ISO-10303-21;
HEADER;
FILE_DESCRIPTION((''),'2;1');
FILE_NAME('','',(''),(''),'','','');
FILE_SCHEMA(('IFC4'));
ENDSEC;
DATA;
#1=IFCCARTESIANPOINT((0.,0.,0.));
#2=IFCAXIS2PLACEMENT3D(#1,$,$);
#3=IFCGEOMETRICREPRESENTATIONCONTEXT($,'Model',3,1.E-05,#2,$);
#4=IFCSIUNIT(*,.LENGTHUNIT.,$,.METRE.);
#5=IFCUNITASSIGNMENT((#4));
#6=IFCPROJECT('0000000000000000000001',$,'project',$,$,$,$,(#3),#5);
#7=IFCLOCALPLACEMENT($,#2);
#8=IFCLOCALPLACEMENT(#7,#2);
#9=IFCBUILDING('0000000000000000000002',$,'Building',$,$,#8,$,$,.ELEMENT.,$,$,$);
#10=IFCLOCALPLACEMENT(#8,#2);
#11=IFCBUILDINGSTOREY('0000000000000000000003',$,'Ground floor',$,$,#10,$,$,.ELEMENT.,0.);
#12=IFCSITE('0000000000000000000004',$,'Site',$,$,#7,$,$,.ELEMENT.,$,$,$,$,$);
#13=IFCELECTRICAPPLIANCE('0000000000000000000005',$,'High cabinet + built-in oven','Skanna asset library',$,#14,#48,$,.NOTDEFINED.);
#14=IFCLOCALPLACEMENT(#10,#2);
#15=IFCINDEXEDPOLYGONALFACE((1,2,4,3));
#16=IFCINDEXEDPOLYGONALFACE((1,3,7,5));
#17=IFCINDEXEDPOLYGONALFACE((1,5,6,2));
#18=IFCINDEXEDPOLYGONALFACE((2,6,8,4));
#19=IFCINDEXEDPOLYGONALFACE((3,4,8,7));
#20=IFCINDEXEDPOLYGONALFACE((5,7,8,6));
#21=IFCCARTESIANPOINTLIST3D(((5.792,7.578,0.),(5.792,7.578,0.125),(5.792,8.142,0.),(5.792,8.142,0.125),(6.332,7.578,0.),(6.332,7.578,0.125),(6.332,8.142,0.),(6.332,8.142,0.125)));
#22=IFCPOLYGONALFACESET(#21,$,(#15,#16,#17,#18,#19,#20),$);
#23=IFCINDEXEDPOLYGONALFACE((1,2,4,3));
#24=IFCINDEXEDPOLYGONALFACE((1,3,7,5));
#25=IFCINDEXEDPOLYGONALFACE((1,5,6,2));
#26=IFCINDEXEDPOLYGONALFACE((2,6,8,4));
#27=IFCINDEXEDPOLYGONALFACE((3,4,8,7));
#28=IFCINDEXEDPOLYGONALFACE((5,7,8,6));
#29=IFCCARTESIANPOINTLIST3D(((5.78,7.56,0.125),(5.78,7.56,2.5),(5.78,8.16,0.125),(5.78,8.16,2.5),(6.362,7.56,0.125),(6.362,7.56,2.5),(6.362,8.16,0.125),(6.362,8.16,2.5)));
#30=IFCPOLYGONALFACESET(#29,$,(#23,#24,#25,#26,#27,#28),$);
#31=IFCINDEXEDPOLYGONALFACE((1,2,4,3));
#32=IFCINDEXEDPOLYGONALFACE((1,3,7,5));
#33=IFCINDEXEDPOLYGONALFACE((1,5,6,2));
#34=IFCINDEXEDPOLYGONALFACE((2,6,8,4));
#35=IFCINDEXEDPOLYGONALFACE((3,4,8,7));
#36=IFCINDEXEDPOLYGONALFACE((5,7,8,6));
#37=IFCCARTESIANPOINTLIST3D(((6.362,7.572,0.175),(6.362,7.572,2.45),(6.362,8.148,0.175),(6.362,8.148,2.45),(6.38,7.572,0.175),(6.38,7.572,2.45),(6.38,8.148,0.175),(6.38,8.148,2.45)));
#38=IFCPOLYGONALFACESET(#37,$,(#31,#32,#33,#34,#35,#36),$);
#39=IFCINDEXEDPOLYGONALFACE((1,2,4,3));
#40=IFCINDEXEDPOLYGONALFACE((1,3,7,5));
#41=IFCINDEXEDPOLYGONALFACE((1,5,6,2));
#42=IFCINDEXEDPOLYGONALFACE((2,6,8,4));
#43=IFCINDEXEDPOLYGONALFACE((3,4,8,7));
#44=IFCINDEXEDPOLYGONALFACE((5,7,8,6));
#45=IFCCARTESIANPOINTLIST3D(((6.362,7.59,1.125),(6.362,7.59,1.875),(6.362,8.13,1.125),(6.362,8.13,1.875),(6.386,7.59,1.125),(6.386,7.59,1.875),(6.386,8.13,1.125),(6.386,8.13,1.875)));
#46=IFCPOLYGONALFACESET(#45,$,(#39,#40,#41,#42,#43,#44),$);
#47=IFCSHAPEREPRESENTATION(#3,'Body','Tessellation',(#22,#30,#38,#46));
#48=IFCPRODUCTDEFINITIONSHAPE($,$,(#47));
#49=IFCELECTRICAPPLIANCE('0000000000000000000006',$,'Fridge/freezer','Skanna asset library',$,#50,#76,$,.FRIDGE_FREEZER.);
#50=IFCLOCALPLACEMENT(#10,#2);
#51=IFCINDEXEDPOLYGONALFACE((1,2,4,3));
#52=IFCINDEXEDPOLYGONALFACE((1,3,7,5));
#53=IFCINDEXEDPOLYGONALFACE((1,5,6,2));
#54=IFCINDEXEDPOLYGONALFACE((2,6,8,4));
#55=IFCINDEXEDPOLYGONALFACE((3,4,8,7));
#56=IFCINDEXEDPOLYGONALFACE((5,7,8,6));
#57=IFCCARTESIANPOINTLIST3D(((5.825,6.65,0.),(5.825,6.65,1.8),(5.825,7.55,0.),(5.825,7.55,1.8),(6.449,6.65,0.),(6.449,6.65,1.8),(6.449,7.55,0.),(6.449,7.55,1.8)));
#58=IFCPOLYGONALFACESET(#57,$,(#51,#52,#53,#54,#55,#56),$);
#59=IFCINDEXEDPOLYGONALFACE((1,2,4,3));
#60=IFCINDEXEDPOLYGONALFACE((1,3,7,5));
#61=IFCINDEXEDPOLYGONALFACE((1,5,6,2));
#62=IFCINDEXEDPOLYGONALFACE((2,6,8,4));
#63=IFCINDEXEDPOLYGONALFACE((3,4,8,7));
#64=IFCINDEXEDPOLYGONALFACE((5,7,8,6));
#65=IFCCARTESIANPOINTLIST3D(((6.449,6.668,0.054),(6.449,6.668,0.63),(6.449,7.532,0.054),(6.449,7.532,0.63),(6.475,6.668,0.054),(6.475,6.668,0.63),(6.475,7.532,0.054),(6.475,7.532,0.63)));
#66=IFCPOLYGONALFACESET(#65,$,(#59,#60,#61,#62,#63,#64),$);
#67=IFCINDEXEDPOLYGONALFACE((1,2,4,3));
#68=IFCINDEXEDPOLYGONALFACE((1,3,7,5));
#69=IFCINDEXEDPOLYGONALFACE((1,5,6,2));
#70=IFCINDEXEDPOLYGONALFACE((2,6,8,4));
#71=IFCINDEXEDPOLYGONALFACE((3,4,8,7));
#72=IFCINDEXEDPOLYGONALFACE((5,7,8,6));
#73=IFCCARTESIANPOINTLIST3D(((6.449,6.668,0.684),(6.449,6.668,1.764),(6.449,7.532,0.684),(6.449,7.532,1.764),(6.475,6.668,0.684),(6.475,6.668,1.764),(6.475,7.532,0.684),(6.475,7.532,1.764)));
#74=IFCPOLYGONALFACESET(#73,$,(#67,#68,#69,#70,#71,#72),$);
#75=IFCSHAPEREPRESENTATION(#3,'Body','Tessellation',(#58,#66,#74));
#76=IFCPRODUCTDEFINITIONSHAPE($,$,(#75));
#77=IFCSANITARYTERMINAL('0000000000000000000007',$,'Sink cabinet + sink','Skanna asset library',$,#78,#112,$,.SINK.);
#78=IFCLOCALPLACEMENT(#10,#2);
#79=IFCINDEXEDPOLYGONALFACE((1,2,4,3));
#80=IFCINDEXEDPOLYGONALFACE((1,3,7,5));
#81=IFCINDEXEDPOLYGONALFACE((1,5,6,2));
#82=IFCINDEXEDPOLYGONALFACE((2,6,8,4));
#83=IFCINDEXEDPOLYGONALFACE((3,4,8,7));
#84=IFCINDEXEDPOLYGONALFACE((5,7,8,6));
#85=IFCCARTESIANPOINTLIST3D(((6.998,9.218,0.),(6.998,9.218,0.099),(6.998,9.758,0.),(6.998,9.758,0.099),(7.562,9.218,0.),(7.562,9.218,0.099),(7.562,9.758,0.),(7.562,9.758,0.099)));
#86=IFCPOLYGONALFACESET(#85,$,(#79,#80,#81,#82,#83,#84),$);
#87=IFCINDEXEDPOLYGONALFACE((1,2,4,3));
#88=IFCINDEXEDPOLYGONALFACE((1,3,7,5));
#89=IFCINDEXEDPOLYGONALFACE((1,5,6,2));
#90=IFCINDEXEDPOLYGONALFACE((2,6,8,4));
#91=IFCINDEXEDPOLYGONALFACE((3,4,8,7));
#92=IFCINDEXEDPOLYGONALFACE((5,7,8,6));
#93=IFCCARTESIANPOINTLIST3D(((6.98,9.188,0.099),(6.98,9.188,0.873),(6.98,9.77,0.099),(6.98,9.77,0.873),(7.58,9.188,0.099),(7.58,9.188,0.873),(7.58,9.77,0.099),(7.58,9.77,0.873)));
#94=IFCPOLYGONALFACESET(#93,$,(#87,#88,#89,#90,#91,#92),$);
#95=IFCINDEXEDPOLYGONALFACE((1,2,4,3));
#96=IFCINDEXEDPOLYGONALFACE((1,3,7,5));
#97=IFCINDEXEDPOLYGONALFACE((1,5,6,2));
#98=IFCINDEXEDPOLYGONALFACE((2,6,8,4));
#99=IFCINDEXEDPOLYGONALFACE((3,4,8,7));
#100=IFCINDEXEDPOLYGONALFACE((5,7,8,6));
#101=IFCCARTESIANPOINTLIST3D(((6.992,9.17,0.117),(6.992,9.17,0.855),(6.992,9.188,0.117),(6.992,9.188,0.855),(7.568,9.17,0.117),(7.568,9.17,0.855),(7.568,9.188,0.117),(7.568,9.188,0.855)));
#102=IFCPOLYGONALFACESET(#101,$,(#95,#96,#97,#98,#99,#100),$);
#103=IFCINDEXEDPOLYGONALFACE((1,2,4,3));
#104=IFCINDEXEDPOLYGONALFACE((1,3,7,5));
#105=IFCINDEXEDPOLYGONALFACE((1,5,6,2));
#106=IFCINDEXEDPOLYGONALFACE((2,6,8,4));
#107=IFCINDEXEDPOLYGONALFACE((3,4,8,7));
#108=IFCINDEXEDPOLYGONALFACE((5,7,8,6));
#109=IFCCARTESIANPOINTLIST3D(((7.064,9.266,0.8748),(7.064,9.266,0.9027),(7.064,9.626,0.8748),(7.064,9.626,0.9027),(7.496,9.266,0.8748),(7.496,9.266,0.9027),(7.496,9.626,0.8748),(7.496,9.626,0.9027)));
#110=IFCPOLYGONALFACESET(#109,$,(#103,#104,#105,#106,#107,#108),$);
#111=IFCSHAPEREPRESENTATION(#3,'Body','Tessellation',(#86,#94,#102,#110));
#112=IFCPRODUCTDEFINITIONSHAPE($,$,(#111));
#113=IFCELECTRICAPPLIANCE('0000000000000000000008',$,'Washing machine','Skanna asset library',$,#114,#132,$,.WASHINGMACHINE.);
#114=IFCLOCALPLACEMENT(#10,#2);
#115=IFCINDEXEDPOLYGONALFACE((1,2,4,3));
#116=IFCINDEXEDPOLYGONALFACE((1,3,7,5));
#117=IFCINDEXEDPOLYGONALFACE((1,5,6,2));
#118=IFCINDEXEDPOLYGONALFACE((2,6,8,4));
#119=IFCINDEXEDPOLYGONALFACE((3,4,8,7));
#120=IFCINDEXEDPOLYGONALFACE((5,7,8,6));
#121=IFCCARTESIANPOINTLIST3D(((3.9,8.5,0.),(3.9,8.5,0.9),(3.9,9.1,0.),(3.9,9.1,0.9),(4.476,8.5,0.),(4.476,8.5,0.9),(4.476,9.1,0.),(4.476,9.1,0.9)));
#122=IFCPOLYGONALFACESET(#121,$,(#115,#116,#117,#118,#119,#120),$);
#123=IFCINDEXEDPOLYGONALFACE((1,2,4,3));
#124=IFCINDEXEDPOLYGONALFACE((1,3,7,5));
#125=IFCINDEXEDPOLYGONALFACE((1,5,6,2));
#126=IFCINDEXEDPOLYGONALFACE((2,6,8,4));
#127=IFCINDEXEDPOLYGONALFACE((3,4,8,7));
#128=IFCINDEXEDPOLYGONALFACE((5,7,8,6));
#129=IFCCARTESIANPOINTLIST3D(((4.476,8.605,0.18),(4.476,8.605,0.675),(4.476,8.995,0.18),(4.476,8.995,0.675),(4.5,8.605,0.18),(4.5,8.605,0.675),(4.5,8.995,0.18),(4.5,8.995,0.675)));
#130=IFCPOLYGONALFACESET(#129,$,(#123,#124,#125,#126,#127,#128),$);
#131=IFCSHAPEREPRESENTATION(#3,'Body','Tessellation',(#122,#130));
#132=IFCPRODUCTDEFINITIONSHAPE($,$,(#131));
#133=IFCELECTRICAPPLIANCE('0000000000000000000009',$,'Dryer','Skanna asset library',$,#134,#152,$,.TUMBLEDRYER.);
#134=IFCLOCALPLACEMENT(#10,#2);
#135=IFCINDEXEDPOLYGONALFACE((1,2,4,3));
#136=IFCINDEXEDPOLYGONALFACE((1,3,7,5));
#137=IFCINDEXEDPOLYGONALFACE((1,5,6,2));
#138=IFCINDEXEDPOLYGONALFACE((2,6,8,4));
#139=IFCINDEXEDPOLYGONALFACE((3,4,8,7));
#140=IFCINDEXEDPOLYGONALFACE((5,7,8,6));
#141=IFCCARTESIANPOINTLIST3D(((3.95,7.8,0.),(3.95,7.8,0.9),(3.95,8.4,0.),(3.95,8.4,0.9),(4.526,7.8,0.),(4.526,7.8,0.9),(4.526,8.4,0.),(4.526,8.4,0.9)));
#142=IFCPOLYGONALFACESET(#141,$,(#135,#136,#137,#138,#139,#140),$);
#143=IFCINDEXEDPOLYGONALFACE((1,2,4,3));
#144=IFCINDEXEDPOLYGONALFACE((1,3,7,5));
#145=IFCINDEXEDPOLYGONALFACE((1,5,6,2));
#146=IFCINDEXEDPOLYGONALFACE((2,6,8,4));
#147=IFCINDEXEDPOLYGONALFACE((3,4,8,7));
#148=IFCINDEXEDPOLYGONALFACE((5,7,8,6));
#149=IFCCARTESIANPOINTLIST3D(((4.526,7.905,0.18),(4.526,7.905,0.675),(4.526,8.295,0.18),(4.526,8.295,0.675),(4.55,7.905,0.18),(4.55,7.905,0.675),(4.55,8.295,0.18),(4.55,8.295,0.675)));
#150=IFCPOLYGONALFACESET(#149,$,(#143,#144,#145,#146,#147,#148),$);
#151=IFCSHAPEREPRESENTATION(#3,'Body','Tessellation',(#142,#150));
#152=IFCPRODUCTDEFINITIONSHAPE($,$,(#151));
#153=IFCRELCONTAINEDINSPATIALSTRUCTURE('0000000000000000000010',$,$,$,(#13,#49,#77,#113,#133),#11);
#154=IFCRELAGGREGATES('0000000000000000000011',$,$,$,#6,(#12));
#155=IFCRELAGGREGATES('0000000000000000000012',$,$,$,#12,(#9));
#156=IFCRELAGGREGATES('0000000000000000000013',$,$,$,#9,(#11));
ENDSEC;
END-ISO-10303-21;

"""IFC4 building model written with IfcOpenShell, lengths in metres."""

from ifc_helpers import new_model, si_unit, frame, frame_2d, origin, place, context, project, spatial, rectangle, extrude, element, save


model = new_model("IFC4")

# Units and contexts
model_context = context("Model", 3, precision=1e-05, world=origin())
ifc_project = project(units=[si_unit("LENGTHUNIT", "METRE")], contexts=[model_context])

# Site, building, storey
site_placement = place(None, origin())
site = spatial("IfcSite", under=ifc_project, at=site_placement, Name="Site", CompositionType="ELEMENT")
building_placement = place(site_placement, origin())
building = spatial("IfcBuilding", under=site, at=building_placement, Name="Building", CompositionType="ELEMENT")
storey_placement = place(building_placement, origin())
storey = spatial("IfcBuildingStorey", under=building, at=storey_placement, Name="Ground floor", CompositionType="ELEMENT", Elevation=0.0)

# Electric appliances
electric_appliance_1_placement = place(storey_placement, frame((6.08, 7.86, 0.0), z_axis=(0.0, 0.0, 1.0), x_axis=(0.0, 1.0, 0.0)))
element("IfcElectricAppliance", 1, at=electric_appliance_1_placement, inside=storey, Name="High cabinet + built-in oven", Description="Skanna asset library", PredefinedType="NOTDEFINED", context=model_context, shape_type="SweptSolid", body=[
    extrude(rectangle(XDim=0.564, YDim=0.54, at=frame_2d((0.0, 0.018))), origin(), (0.0, 0.0, 1.0), 0.125),
    extrude(rectangle(XDim=0.6, YDim=0.582, at=frame_2d((0.0, 0.009))), frame((0.0, 0.0, 0.125)), (0.0, 0.0, 1.0), 2.375),
    extrude(rectangle(XDim=0.576, YDim=0.018, at=frame_2d((0.0, -0.291))), frame((0.0, 0.0, 0.175)), (0.0, 0.0, 1.0), 2.275),
    extrude(rectangle(XDim=0.54, YDim=0.024, at=frame_2d((0.0, -0.294))), frame((0.0, 0.0, 1.125)), (0.0, 0.0, 1.0), 0.75),
])
electric_appliance_2_placement = place(storey_placement, frame((6.15, 7.1, 0.0), z_axis=(0.0, 0.0, 1.0), x_axis=(0.0, 1.0, 0.0)))
element("IfcElectricAppliance", 2, at=electric_appliance_2_placement, inside=storey, Name="Fridge/freezer", Description="Skanna asset library", PredefinedType="FRIDGE_FREEZER", context=model_context, shape_type="SweptSolid", body=[
    extrude(rectangle(XDim=0.9, YDim=0.624, at=frame_2d((0.0, 0.013))), origin(), (0.0, 0.0, 1.0), 1.8),
    extrude(rectangle(XDim=0.864, YDim=0.026, at=frame_2d((0.0, -0.312))), frame((0.0, 0.0, 0.054)), (0.0, 0.0, 1.0), 0.576),
    extrude(rectangle(XDim=0.864, YDim=0.026, at=frame_2d((0.0, -0.312))), frame((0.0, 0.0, 0.684)), (0.0, 0.0, 1.0), 1.08),
])

# Sanitary terminal
sanitary_terminal_placement = place(storey_placement, frame((7.28, 9.47, 0.0), z_axis=(0.0, 0.0, 1.0), x_axis=(1.0, 0.0, 0.0)))
element("IfcSanitaryTerminal", 3, at=sanitary_terminal_placement, inside=storey, Name="Sink cabinet + sink", Description="Skanna asset library", PredefinedType="SINK", context=model_context, shape_type="SweptSolid", body=[
    extrude(rectangle(XDim=0.564, YDim=0.54, at=frame_2d((0.0, 0.018))), origin(), (0.0, 0.0, 1.0), 0.099),
    extrude(rectangle(XDim=0.6, YDim=0.582, at=frame_2d((0.0, 0.009))), frame((0.0, 0.0, 0.099)), (0.0, 0.0, 1.0), 0.774),
    extrude(rectangle(XDim=0.576, YDim=0.018, at=frame_2d((0.0, -0.291))), frame((0.0, 0.0, 0.117)), (0.0, 0.0, 1.0), 0.738),
    extrude(rectangle(XDim=0.432, YDim=0.36, at=frame_2d((0.0, -0.024))), frame((0.0, 0.0, 0.8748)), (0.0, 0.0, 1.0), 0.0279),
])

# Electric appliances
electric_appliance_3_placement = place(storey_placement, frame((4.2, 8.8, 0.0), z_axis=(0.0, 0.0, 1.0), x_axis=(0.0, 1.0, 0.0)))
element("IfcElectricAppliance", 4, at=electric_appliance_3_placement, inside=storey, Name="Washing machine", Description="Skanna asset library", PredefinedType="WASHINGMACHINE", context=model_context, shape_type="SweptSolid", body=[
    extrude(rectangle(XDim=0.6, YDim=0.576, at=frame_2d((0.0, 0.012))), origin(), (0.0, 0.0, 1.0), 0.9),
    extrude(rectangle(XDim=0.39, YDim=0.024, at=frame_2d((0.0, -0.288))), frame((0.0, 0.0, 0.18)), (0.0, 0.0, 1.0), 0.495),
])
electric_appliance_4_placement = place(storey_placement, frame((4.25, 8.1, 0.0), z_axis=(0.0, 0.0, 1.0), x_axis=(0.0, 1.0, 0.0)))
element("IfcElectricAppliance", 5, at=electric_appliance_4_placement, inside=storey, Name="Dryer", Description="Skanna asset library", PredefinedType="TUMBLEDRYER", context=model_context, shape_type="SweptSolid", body=[
    extrude(rectangle(XDim=0.6, YDim=0.576, at=frame_2d((0.0, 0.012))), origin(), (0.0, 0.0, 1.0), 0.9),
    extrude(rectangle(XDim=0.39, YDim=0.024, at=frame_2d((0.0, -0.288))), frame((0.0, 0.0, 0.18)), (0.0, 0.0, 1.0), 0.495),
])

save(model, "model.ifc")
